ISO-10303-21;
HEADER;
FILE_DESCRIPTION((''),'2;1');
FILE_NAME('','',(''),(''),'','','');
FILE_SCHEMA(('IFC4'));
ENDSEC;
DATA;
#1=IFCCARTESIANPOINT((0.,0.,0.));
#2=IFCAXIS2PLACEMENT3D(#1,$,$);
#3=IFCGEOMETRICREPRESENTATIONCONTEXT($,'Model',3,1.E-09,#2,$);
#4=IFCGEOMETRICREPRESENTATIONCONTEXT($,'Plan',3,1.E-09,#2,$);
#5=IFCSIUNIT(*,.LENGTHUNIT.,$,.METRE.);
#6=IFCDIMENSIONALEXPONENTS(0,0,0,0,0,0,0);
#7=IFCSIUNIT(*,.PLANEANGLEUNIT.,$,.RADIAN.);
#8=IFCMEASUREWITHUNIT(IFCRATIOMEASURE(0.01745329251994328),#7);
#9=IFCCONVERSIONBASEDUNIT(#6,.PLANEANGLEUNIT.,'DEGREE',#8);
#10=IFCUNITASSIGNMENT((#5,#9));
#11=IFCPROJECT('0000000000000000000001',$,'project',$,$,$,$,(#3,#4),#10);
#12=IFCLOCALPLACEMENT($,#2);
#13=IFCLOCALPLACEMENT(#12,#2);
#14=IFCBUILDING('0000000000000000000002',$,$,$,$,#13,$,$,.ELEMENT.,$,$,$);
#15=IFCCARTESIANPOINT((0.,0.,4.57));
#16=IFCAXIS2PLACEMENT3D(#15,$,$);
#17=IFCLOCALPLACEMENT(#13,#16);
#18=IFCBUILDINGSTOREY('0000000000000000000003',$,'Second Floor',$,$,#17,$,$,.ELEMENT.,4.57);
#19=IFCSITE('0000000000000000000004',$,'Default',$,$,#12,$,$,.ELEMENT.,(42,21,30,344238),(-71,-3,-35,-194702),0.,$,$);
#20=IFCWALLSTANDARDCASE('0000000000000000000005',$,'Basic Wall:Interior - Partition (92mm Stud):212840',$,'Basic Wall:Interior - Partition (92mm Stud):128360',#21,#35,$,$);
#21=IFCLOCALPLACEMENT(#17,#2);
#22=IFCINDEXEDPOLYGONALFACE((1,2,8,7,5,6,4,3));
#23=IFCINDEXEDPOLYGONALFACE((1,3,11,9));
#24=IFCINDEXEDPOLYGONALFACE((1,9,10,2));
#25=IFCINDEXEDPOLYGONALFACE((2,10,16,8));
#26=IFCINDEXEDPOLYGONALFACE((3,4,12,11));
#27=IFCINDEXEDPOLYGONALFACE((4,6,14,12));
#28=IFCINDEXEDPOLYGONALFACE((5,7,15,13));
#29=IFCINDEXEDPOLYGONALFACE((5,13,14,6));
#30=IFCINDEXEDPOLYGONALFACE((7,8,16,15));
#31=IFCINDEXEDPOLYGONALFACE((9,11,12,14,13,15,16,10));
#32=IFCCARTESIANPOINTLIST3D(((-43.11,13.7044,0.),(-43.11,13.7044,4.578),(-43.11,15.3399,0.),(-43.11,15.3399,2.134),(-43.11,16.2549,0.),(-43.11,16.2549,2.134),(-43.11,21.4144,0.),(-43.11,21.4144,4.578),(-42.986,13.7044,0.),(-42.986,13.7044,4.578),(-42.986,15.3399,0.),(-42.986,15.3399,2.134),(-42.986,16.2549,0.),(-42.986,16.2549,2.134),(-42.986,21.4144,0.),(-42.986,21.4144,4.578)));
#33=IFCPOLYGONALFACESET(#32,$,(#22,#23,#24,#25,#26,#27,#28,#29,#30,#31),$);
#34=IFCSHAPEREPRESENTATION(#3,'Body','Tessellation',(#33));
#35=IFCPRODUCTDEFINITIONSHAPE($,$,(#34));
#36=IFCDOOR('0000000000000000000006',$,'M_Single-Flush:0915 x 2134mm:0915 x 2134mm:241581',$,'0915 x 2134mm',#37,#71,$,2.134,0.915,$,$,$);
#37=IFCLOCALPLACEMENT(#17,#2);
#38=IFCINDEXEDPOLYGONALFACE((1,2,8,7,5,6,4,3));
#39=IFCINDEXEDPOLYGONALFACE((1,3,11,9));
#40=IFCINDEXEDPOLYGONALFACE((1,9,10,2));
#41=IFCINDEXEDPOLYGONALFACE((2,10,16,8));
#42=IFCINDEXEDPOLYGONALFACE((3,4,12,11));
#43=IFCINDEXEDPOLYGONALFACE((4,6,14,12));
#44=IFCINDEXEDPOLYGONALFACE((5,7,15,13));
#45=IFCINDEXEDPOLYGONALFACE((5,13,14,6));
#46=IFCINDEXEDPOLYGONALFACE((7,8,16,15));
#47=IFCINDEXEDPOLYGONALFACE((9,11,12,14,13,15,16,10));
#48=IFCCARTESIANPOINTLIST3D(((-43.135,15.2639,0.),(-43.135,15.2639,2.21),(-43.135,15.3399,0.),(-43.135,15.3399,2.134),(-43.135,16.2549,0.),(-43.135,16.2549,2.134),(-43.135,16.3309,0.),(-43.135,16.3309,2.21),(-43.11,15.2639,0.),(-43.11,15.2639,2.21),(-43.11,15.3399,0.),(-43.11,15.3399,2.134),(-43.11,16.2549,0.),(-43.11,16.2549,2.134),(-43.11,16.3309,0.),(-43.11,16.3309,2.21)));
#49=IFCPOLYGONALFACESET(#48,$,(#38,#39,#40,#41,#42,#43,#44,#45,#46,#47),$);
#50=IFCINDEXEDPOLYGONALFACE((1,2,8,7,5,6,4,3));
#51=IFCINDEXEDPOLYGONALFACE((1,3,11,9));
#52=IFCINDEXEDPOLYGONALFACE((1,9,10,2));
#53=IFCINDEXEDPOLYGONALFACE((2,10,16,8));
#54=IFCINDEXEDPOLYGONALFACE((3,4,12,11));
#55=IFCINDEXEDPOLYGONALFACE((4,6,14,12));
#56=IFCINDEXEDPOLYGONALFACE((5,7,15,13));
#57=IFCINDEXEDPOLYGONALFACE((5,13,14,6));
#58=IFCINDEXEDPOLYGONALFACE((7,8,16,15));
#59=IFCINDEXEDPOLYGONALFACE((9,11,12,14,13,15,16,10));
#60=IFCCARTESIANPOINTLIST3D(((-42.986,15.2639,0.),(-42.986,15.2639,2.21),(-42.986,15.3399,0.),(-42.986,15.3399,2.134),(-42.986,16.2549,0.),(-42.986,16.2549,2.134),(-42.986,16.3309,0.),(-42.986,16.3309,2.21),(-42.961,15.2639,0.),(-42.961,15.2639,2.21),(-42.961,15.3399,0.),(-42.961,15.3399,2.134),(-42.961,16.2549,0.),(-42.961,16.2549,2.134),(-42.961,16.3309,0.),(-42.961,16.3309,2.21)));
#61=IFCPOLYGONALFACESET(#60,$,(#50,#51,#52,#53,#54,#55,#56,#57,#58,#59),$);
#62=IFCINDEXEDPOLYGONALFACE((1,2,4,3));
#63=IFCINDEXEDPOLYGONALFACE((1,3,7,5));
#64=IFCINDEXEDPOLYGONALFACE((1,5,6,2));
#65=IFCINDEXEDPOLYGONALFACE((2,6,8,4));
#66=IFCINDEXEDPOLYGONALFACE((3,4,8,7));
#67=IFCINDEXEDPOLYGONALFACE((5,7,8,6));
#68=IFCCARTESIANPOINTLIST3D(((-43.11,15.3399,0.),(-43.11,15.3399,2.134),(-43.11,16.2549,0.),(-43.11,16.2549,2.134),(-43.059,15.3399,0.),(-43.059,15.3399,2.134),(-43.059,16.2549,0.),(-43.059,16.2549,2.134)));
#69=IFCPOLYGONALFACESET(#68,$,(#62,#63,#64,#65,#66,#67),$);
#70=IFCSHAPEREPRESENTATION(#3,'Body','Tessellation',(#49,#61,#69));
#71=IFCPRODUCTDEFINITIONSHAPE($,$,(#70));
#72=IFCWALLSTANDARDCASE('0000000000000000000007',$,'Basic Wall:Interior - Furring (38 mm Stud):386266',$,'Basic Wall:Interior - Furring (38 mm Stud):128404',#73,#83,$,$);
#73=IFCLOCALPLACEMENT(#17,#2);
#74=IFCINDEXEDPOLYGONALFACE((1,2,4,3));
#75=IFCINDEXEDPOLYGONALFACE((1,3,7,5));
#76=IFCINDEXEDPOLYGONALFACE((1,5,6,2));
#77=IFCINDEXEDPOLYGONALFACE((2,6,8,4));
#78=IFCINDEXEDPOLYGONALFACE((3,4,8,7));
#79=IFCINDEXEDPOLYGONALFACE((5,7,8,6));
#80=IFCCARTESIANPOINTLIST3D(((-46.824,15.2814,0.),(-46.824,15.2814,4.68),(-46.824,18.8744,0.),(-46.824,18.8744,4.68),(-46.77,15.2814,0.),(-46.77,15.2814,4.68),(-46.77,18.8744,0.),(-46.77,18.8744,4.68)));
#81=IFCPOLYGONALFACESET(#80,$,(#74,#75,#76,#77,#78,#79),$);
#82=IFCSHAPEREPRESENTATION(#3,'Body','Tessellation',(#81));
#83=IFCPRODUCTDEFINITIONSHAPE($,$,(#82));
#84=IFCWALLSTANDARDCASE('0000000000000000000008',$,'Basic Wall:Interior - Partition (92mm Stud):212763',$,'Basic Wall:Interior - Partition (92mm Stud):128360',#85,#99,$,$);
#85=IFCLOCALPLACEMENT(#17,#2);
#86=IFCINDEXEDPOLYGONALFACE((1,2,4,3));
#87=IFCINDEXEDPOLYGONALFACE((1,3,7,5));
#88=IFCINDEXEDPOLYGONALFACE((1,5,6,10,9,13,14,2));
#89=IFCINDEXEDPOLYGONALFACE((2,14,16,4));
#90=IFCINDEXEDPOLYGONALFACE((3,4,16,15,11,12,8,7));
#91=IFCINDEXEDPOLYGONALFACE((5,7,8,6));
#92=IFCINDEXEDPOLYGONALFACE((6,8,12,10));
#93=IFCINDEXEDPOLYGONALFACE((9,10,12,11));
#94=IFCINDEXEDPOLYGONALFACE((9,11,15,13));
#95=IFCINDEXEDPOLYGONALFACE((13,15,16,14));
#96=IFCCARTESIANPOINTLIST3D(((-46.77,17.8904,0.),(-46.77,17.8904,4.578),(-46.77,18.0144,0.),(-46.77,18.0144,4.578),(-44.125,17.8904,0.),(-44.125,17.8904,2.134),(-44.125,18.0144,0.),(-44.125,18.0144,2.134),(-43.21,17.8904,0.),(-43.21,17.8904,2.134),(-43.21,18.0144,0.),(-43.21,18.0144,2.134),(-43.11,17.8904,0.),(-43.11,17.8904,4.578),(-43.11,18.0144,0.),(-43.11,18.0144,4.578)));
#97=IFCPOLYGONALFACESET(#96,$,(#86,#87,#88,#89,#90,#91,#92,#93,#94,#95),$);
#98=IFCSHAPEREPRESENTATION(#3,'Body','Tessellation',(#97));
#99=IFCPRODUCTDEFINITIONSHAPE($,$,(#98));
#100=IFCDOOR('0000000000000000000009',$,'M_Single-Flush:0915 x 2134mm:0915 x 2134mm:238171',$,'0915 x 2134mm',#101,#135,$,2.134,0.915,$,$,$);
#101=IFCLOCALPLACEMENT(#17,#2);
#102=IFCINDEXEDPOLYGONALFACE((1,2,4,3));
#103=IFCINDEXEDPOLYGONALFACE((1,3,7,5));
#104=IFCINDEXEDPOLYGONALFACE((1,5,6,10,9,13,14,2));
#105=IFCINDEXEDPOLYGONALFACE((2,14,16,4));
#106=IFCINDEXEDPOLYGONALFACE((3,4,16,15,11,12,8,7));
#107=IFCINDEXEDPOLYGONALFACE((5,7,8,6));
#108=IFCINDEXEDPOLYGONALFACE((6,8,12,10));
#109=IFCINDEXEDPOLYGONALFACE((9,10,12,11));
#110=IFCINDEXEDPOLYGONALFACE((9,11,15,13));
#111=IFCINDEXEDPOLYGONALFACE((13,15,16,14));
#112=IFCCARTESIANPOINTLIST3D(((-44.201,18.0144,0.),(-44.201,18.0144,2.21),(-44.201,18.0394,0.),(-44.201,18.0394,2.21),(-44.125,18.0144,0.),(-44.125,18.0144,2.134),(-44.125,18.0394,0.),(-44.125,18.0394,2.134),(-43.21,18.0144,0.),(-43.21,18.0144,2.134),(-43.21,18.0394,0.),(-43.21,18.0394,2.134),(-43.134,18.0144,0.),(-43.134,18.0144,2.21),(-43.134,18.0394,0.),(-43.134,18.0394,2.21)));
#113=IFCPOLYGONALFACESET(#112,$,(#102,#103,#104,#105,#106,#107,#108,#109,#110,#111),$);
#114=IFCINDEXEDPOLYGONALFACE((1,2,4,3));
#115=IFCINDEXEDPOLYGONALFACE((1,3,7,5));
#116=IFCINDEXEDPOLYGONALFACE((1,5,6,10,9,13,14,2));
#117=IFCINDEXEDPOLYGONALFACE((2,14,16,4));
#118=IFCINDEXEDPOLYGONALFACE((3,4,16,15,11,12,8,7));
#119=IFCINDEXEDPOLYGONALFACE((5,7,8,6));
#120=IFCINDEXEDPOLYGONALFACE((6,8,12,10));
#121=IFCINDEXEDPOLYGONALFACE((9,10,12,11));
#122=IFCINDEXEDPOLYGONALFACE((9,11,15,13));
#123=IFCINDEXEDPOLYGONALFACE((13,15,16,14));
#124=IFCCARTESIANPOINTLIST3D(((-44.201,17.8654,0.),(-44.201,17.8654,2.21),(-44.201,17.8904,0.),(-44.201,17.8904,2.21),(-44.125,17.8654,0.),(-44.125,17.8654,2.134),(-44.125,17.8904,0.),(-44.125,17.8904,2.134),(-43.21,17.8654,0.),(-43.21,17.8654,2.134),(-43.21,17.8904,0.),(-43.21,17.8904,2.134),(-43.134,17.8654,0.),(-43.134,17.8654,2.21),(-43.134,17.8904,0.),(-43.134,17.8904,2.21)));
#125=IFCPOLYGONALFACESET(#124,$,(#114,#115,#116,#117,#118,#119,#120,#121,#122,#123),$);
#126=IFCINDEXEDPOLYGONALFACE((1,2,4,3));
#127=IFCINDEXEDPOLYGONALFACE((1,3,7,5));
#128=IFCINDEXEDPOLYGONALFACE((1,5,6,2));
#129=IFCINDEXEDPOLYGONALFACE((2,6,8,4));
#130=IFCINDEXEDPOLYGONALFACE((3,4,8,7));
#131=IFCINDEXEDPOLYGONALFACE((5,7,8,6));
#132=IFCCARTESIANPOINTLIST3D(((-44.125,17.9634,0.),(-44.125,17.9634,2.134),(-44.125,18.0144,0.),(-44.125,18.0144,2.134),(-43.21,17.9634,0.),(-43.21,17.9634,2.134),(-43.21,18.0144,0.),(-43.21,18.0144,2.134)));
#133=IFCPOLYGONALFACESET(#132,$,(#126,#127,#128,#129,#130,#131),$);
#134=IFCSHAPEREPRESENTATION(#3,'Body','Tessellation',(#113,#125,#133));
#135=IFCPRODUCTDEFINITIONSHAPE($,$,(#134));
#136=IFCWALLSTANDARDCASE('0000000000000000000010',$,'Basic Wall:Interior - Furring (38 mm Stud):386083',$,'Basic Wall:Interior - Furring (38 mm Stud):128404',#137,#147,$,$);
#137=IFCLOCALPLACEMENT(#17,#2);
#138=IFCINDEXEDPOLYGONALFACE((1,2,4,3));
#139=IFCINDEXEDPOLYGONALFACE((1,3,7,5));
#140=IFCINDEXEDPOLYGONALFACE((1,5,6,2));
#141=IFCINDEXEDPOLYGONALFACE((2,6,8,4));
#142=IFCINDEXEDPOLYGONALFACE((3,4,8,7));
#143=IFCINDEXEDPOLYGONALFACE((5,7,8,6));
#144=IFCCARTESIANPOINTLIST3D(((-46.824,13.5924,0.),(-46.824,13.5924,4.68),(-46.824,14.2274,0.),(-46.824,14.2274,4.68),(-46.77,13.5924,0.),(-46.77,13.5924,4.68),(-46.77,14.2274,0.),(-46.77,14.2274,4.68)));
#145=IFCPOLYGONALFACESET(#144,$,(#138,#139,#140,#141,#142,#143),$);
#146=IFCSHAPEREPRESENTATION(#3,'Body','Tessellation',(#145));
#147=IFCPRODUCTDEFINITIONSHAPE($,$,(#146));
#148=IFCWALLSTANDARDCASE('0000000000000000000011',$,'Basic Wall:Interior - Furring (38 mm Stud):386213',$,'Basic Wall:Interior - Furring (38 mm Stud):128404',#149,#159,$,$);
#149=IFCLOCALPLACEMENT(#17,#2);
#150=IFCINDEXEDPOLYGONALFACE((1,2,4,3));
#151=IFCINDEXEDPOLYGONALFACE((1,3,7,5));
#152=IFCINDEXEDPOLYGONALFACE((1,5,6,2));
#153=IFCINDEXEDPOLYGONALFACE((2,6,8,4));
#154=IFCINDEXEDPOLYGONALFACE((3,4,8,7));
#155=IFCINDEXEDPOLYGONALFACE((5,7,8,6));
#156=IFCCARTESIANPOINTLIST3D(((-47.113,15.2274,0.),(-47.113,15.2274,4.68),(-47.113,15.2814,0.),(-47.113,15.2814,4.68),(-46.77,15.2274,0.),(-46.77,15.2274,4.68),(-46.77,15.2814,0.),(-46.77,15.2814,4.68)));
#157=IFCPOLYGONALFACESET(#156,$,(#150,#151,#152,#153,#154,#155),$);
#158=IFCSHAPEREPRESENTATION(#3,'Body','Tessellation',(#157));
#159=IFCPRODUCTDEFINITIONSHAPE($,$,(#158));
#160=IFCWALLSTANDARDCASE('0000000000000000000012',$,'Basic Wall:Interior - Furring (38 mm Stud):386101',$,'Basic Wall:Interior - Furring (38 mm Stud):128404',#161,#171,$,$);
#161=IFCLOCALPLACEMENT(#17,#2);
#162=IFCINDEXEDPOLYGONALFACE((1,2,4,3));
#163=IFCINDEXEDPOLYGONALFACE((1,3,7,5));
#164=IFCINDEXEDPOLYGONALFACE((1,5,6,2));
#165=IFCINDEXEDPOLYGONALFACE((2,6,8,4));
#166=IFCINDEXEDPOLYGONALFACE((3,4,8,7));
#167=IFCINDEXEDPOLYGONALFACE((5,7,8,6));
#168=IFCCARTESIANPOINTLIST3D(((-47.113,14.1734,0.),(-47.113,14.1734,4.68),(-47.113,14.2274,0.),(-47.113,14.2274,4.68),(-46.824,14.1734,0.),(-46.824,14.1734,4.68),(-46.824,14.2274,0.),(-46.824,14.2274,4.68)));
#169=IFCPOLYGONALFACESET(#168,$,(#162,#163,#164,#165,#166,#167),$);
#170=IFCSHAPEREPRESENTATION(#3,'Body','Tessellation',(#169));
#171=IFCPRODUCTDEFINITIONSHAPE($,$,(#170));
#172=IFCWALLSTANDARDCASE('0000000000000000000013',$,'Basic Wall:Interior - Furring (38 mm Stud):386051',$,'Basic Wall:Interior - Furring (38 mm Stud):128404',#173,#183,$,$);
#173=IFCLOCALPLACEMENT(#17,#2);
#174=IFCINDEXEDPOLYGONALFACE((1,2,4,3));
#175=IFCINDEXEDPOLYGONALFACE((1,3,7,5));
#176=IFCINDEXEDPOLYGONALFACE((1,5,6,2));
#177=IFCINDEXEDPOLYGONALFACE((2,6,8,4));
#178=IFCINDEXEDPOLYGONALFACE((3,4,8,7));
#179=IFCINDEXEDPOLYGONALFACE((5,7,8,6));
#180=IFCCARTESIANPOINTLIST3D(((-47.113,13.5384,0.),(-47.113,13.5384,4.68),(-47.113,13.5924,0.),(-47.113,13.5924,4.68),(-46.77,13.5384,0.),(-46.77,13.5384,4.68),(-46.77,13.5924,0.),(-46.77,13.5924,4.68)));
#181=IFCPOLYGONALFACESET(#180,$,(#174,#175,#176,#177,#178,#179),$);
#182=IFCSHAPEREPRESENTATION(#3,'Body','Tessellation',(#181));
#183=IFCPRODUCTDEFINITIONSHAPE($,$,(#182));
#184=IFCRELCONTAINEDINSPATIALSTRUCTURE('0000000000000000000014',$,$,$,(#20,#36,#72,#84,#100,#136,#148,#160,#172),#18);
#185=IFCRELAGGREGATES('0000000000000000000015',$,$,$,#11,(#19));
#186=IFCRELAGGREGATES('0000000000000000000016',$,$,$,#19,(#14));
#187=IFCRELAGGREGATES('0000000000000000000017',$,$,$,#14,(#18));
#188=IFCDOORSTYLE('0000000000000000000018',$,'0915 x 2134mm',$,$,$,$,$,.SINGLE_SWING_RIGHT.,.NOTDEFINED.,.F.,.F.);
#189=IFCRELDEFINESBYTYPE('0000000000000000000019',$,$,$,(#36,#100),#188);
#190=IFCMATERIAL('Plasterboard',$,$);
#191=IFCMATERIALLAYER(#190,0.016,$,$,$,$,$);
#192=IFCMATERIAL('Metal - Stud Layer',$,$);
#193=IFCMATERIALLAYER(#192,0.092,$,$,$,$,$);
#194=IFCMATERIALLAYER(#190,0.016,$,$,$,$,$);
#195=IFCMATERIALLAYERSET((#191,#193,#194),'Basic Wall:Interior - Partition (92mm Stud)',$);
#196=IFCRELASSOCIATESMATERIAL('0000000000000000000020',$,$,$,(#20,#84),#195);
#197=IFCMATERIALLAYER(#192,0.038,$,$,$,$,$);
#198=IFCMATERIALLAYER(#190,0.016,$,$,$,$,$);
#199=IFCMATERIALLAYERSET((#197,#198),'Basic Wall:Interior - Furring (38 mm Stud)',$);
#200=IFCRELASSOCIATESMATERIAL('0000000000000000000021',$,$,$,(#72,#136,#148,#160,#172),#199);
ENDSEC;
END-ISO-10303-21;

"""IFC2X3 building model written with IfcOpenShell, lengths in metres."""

from ifc_helpers import new_model, entity, si_unit, converted_unit, frame, frame_2d, origin, origin_2d_with_axis, place, context, project, spatial, polyline, rectangle, outline, extrude, source, transform, mapped, material, layer, layer_set, layer_usage, type_object, type_shapes, element, fill, save


model = new_model("IFC2X3")

# Units and contexts
model_context = context("Model", 3, precision=1e-09, world=origin())
plan_context = context("Plan", 3, precision=1e-09, world=origin())
ifc_project = project(units=[si_unit("LENGTHUNIT", "METRE"), converted_unit("PLANEANGLEUNIT", "DEGREE", entity("IfcRatioMeasure", 0.01745329251994328), si_unit("PLANEANGLEUNIT", "RADIAN"), dimensions=[0, 0, 0, 0, 0, 0, 0])], contexts=[model_context, plan_context])

# Site, building, storey
site_placement = place(None, origin())
site = spatial("IfcSite", under=ifc_project, at=site_placement, Name="Default", CompositionType="ELEMENT", RefLatitude=(42, 21, 30, 344238), RefLongitude=(-71, -3, -35, -194702), RefElevation=0.0)
building_placement = place(site_placement, origin())
building = spatial("IfcBuilding", under=site, at=building_placement, CompositionType="ELEMENT")
storey_placement = place(building_placement, frame((0.0, 0.0, 4.57)))
storey = spatial("IfcBuildingStorey", under=building, at=storey_placement, Name="Second Floor", CompositionType="ELEMENT", Elevation=4.57)

# Shared definitions
ifc_material_1 = material(Name="Plasterboard")
ifc_layer_1 = layer(ifc_material_1, 0.016)
ifc_material_2 = material(Name="Metal - Stud Layer")
ifc_layer_2 = layer(ifc_material_2, 0.092)
ifc_layer_3 = layer(ifc_material_1, 0.016)
ifc_layer_set_1 = layer_set([ifc_layer_1, ifc_layer_2, ifc_layer_3], Name="Basic Wall:Interior - Partition (92mm Stud)")
ifc_layer_usage_1 = layer_usage(ifc_layer_set_1, "AXIS2", "NEGATIVE", 0.062)
door_style_1 = type_object("IfcDoorStyle", Name="0915 x 2134mm", ConstructionType="NOTDEFINED", OperationType="SINGLE_SWING_RIGHT", ParameterTakesPrecedence=False, Sizeable=False)
shared_shape_1 = source(origin(), model_context, "Body", "SweptSolid", [
    extrude(outline(polyline([(-0.5335, -1.124), (0.5335, -1.124), (0.5335, 1.086), (0.4575, 1.086), (0.4575, -1.048), (-0.4575, -1.048), (-0.4575, 1.086), (-0.5335, 1.086), (-0.5335, -1.124)])), frame((0.4575, 0.124, 1.086), z_axis=(0.0, 1.0, 0.0), x_axis=(1.0, 0.0, 0.0)), (0.0, 0.0, 1.0), 0.025),
    extrude(outline(polyline([(-1.124, -0.5335), (1.086, -0.5335), (1.086, -0.4575), (-1.048, -0.4575), (-1.048, 0.4575), (1.086, 0.4575), (1.086, 0.5335), (-1.124, 0.5335), (-1.124, -0.5335)])), frame((0.4575, -0.025, 1.086), z_axis=(0.0, 1.0, 0.0), x_axis=(0.0, 0.0, -1.0)), (0.0, 0.0, 1.0), 0.025),
    extrude(rectangle(XDim=0.051, YDim=0.915, at=origin_2d_with_axis()), frame((0.4575, 0.0985, 0.0), z_axis=(0.0, 0.0, 1.0), x_axis=(0.0, 1.0, 0.0)), (0.0, 0.0, 1.0), 2.134),
])
type_shapes(door_style_1, [shared_shape_1])

# Wall, opening, door
wall_1_placement = place(storey_placement, frame((-43.048, 13.7044, 0.0), z_axis=(0.0, 0.0, 1.0), x_axis=(0.0, 1.0, 0.0)))
wall_1 = element("IfcWallStandardCase", 1, at=wall_1_placement, inside=storey, material=ifc_layer_usage_1, Name="Basic Wall:Interior - Partition (92mm Stud):212840", ObjectType="Basic Wall:Interior - Partition (92mm Stud):128360", context=model_context, shape_type="SweptSolid", body=[
    extrude(rectangle(XDim=7.71, YDim=0.124, at=frame_2d((3.855, 0.0), x_axis=(-1.0, 0.0))), origin(), (0.0, 0.0, 1.0), 4.578),
])
opening_1_placement = place(wall_1_placement, frame((1.6355, -0.062, 0.0)))
opening_1 = element("IfcOpeningElement", 2, at=opening_1_placement, cuts=wall_1, ObjectType="Opening", context=model_context, shape_type="SweptSolid", body=[
    extrude(rectangle(XDim=0.915, YDim=2.134, at=frame_2d((1.067, 0.4575), x_axis=(0.0, 1.0))), frame((0.0, 0.0, 0.0), z_axis=(0.0, 1.0, 0.0), x_axis=(0.0, 0.0, 1.0)), (0.0, 0.0, 1.0), 0.124),
])
door_1_placement = place(opening_1_placement, origin())
door_1 = element("IfcDoor", 3, at=door_1_placement, inside=storey, type_object=door_style_1, Name="M_Single-Flush:0915 x 2134mm:0915 x 2134mm:241581", ObjectType="0915 x 2134mm", OverallHeight=2.134, OverallWidth=0.915, context=model_context, shape_type="MappedRepresentation", body=[
    mapped(shared_shape_1, transform((0.0, 0.0, 0.0), scale=1.0)),
])
fill(opening_1, door_1)

# Wall
ifc_layer_4 = layer(ifc_material_2, 0.038)
ifc_layer_5 = layer(ifc_material_1, 0.016)
ifc_layer_set_2 = layer_set([ifc_layer_4, ifc_layer_5], Name="Basic Wall:Interior - Furring (38 mm Stud)")
ifc_layer_usage_2 = layer_usage(ifc_layer_set_2, "AXIS2", "NEGATIVE", 0.027)
wall_2_placement = place(storey_placement, frame((-46.797, 15.2814, 0.0), z_axis=(0.0, 0.0, 1.0), x_axis=(0.0, 1.0, 0.0)))
element("IfcWallStandardCase", 4, at=wall_2_placement, inside=storey, material=ifc_layer_usage_2, Name="Basic Wall:Interior - Furring (38 mm Stud):386266", ObjectType="Basic Wall:Interior - Furring (38 mm Stud):128404", context=model_context, shape_type="SweptSolid", body=[
    extrude(rectangle(XDim=3.5931, YDim=0.054, at=frame_2d((1.7965, 0.0), x_axis=(-1.0, 0.0))), origin(), (0.0, 0.0, 1.0), 4.68),
])

# Wall, opening, door
wall_3_placement = place(storey_placement, frame((-46.77, 17.9524, 0.0)))
wall_3 = element("IfcWallStandardCase", 5, at=wall_3_placement, inside=storey, material=ifc_layer_usage_1, Name="Basic Wall:Interior - Partition (92mm Stud):212763", ObjectType="Basic Wall:Interior - Partition (92mm Stud):128360", context=model_context, shape_type="SweptSolid", body=[
    extrude(rectangle(XDim=3.66, YDim=0.124, at=frame_2d((1.83, 0.0), x_axis=(-1.0, 0.0))), origin(), (0.0, 0.0, 1.0), 4.578),
])
opening_2_placement = place(wall_3_placement, frame((2.645, -0.062, 0.0)))
opening_2 = element("IfcOpeningElement", 6, at=opening_2_placement, cuts=wall_3, ObjectType="Opening", context=model_context, shape_type="SweptSolid", body=[
    extrude(rectangle(XDim=0.915, YDim=2.134, at=frame_2d((1.067, 0.4575), x_axis=(0.0, 1.0))), frame((0.0, 0.0, 0.0), z_axis=(0.0, 1.0, 0.0), x_axis=(0.0, 0.0, 1.0)), (0.0, 0.0, 1.0), 0.124),
])
door_2_placement = place(opening_2_placement, origin())
door_2 = element("IfcDoor", 7, at=door_2_placement, inside=storey, type_object=door_style_1, Name="M_Single-Flush:0915 x 2134mm:0915 x 2134mm:238171", ObjectType="0915 x 2134mm", OverallHeight=2.134, OverallWidth=0.915, context=model_context, shape_type="MappedRepresentation", body=[
    mapped(shared_shape_1, transform((0.0, 0.0, 0.0), scale=1.0)),
])
fill(opening_2, door_2)

# Walls
wall_4_placement = place(storey_placement, frame((-46.797, 13.5924, 0.0), z_axis=(0.0, 0.0, 1.0), x_axis=(0.0, 1.0, 0.0)))
element("IfcWallStandardCase", 8, at=wall_4_placement, inside=storey, material=ifc_layer_usage_2, Name="Basic Wall:Interior - Furring (38 mm Stud):386083", ObjectType="Basic Wall:Interior - Furring (38 mm Stud):128404", context=model_context, shape_type="SweptSolid", body=[
    extrude(rectangle(XDim=0.6349, YDim=0.054, at=frame_2d((0.3175, 0.0), x_axis=(-1.0, 0.0))), origin(), (0.0, 0.0, 1.0), 4.68),
])
wall_5_placement = place(storey_placement, frame((-47.113, 15.2544, 0.0)))
element("IfcWallStandardCase", 9, at=wall_5_placement, inside=storey, material=ifc_layer_usage_2, Name="Basic Wall:Interior - Furring (38 mm Stud):386213", ObjectType="Basic Wall:Interior - Furring (38 mm Stud):128404", context=model_context, shape_type="SweptSolid", body=[
    extrude(rectangle(XDim=0.343, YDim=0.054, at=frame_2d((0.1715, 0.0), x_axis=(-1.0, 0.0))), origin(), (0.0, 0.0, 1.0), 4.68),
])
wall_6_placement = place(storey_placement, frame((-46.824, 14.2004, 0.0), z_axis=(0.0, 0.0, 1.0), x_axis=(-1.0, 0.0, 0.0)))
element("IfcWallStandardCase", 10, at=wall_6_placement, inside=storey, material=ifc_layer_usage_2, Name="Basic Wall:Interior - Furring (38 mm Stud):386101", ObjectType="Basic Wall:Interior - Furring (38 mm Stud):128404", context=model_context, shape_type="SweptSolid", body=[
    extrude(rectangle(XDim=0.289, YDim=0.054, at=frame_2d((0.1445, 0.0), x_axis=(-1.0, 0.0))), origin(), (0.0, 0.0, 1.0), 4.68),
])
wall_7_placement = place(storey_placement, frame((-47.113, 13.5654, 0.0)))
element("IfcWallStandardCase", 11, at=wall_7_placement, inside=storey, material=ifc_layer_usage_2, Name="Basic Wall:Interior - Furring (38 mm Stud):386051", ObjectType="Basic Wall:Interior - Furring (38 mm Stud):128404", context=model_context, shape_type="SweptSolid", body=[
    extrude(rectangle(XDim=0.343, YDim=0.054, at=frame_2d((0.1715, 0.0), x_axis=(-1.0, 0.0))), origin(), (0.0, 0.0, 1.0), 4.68),
])

save(model, "model.ifc")
